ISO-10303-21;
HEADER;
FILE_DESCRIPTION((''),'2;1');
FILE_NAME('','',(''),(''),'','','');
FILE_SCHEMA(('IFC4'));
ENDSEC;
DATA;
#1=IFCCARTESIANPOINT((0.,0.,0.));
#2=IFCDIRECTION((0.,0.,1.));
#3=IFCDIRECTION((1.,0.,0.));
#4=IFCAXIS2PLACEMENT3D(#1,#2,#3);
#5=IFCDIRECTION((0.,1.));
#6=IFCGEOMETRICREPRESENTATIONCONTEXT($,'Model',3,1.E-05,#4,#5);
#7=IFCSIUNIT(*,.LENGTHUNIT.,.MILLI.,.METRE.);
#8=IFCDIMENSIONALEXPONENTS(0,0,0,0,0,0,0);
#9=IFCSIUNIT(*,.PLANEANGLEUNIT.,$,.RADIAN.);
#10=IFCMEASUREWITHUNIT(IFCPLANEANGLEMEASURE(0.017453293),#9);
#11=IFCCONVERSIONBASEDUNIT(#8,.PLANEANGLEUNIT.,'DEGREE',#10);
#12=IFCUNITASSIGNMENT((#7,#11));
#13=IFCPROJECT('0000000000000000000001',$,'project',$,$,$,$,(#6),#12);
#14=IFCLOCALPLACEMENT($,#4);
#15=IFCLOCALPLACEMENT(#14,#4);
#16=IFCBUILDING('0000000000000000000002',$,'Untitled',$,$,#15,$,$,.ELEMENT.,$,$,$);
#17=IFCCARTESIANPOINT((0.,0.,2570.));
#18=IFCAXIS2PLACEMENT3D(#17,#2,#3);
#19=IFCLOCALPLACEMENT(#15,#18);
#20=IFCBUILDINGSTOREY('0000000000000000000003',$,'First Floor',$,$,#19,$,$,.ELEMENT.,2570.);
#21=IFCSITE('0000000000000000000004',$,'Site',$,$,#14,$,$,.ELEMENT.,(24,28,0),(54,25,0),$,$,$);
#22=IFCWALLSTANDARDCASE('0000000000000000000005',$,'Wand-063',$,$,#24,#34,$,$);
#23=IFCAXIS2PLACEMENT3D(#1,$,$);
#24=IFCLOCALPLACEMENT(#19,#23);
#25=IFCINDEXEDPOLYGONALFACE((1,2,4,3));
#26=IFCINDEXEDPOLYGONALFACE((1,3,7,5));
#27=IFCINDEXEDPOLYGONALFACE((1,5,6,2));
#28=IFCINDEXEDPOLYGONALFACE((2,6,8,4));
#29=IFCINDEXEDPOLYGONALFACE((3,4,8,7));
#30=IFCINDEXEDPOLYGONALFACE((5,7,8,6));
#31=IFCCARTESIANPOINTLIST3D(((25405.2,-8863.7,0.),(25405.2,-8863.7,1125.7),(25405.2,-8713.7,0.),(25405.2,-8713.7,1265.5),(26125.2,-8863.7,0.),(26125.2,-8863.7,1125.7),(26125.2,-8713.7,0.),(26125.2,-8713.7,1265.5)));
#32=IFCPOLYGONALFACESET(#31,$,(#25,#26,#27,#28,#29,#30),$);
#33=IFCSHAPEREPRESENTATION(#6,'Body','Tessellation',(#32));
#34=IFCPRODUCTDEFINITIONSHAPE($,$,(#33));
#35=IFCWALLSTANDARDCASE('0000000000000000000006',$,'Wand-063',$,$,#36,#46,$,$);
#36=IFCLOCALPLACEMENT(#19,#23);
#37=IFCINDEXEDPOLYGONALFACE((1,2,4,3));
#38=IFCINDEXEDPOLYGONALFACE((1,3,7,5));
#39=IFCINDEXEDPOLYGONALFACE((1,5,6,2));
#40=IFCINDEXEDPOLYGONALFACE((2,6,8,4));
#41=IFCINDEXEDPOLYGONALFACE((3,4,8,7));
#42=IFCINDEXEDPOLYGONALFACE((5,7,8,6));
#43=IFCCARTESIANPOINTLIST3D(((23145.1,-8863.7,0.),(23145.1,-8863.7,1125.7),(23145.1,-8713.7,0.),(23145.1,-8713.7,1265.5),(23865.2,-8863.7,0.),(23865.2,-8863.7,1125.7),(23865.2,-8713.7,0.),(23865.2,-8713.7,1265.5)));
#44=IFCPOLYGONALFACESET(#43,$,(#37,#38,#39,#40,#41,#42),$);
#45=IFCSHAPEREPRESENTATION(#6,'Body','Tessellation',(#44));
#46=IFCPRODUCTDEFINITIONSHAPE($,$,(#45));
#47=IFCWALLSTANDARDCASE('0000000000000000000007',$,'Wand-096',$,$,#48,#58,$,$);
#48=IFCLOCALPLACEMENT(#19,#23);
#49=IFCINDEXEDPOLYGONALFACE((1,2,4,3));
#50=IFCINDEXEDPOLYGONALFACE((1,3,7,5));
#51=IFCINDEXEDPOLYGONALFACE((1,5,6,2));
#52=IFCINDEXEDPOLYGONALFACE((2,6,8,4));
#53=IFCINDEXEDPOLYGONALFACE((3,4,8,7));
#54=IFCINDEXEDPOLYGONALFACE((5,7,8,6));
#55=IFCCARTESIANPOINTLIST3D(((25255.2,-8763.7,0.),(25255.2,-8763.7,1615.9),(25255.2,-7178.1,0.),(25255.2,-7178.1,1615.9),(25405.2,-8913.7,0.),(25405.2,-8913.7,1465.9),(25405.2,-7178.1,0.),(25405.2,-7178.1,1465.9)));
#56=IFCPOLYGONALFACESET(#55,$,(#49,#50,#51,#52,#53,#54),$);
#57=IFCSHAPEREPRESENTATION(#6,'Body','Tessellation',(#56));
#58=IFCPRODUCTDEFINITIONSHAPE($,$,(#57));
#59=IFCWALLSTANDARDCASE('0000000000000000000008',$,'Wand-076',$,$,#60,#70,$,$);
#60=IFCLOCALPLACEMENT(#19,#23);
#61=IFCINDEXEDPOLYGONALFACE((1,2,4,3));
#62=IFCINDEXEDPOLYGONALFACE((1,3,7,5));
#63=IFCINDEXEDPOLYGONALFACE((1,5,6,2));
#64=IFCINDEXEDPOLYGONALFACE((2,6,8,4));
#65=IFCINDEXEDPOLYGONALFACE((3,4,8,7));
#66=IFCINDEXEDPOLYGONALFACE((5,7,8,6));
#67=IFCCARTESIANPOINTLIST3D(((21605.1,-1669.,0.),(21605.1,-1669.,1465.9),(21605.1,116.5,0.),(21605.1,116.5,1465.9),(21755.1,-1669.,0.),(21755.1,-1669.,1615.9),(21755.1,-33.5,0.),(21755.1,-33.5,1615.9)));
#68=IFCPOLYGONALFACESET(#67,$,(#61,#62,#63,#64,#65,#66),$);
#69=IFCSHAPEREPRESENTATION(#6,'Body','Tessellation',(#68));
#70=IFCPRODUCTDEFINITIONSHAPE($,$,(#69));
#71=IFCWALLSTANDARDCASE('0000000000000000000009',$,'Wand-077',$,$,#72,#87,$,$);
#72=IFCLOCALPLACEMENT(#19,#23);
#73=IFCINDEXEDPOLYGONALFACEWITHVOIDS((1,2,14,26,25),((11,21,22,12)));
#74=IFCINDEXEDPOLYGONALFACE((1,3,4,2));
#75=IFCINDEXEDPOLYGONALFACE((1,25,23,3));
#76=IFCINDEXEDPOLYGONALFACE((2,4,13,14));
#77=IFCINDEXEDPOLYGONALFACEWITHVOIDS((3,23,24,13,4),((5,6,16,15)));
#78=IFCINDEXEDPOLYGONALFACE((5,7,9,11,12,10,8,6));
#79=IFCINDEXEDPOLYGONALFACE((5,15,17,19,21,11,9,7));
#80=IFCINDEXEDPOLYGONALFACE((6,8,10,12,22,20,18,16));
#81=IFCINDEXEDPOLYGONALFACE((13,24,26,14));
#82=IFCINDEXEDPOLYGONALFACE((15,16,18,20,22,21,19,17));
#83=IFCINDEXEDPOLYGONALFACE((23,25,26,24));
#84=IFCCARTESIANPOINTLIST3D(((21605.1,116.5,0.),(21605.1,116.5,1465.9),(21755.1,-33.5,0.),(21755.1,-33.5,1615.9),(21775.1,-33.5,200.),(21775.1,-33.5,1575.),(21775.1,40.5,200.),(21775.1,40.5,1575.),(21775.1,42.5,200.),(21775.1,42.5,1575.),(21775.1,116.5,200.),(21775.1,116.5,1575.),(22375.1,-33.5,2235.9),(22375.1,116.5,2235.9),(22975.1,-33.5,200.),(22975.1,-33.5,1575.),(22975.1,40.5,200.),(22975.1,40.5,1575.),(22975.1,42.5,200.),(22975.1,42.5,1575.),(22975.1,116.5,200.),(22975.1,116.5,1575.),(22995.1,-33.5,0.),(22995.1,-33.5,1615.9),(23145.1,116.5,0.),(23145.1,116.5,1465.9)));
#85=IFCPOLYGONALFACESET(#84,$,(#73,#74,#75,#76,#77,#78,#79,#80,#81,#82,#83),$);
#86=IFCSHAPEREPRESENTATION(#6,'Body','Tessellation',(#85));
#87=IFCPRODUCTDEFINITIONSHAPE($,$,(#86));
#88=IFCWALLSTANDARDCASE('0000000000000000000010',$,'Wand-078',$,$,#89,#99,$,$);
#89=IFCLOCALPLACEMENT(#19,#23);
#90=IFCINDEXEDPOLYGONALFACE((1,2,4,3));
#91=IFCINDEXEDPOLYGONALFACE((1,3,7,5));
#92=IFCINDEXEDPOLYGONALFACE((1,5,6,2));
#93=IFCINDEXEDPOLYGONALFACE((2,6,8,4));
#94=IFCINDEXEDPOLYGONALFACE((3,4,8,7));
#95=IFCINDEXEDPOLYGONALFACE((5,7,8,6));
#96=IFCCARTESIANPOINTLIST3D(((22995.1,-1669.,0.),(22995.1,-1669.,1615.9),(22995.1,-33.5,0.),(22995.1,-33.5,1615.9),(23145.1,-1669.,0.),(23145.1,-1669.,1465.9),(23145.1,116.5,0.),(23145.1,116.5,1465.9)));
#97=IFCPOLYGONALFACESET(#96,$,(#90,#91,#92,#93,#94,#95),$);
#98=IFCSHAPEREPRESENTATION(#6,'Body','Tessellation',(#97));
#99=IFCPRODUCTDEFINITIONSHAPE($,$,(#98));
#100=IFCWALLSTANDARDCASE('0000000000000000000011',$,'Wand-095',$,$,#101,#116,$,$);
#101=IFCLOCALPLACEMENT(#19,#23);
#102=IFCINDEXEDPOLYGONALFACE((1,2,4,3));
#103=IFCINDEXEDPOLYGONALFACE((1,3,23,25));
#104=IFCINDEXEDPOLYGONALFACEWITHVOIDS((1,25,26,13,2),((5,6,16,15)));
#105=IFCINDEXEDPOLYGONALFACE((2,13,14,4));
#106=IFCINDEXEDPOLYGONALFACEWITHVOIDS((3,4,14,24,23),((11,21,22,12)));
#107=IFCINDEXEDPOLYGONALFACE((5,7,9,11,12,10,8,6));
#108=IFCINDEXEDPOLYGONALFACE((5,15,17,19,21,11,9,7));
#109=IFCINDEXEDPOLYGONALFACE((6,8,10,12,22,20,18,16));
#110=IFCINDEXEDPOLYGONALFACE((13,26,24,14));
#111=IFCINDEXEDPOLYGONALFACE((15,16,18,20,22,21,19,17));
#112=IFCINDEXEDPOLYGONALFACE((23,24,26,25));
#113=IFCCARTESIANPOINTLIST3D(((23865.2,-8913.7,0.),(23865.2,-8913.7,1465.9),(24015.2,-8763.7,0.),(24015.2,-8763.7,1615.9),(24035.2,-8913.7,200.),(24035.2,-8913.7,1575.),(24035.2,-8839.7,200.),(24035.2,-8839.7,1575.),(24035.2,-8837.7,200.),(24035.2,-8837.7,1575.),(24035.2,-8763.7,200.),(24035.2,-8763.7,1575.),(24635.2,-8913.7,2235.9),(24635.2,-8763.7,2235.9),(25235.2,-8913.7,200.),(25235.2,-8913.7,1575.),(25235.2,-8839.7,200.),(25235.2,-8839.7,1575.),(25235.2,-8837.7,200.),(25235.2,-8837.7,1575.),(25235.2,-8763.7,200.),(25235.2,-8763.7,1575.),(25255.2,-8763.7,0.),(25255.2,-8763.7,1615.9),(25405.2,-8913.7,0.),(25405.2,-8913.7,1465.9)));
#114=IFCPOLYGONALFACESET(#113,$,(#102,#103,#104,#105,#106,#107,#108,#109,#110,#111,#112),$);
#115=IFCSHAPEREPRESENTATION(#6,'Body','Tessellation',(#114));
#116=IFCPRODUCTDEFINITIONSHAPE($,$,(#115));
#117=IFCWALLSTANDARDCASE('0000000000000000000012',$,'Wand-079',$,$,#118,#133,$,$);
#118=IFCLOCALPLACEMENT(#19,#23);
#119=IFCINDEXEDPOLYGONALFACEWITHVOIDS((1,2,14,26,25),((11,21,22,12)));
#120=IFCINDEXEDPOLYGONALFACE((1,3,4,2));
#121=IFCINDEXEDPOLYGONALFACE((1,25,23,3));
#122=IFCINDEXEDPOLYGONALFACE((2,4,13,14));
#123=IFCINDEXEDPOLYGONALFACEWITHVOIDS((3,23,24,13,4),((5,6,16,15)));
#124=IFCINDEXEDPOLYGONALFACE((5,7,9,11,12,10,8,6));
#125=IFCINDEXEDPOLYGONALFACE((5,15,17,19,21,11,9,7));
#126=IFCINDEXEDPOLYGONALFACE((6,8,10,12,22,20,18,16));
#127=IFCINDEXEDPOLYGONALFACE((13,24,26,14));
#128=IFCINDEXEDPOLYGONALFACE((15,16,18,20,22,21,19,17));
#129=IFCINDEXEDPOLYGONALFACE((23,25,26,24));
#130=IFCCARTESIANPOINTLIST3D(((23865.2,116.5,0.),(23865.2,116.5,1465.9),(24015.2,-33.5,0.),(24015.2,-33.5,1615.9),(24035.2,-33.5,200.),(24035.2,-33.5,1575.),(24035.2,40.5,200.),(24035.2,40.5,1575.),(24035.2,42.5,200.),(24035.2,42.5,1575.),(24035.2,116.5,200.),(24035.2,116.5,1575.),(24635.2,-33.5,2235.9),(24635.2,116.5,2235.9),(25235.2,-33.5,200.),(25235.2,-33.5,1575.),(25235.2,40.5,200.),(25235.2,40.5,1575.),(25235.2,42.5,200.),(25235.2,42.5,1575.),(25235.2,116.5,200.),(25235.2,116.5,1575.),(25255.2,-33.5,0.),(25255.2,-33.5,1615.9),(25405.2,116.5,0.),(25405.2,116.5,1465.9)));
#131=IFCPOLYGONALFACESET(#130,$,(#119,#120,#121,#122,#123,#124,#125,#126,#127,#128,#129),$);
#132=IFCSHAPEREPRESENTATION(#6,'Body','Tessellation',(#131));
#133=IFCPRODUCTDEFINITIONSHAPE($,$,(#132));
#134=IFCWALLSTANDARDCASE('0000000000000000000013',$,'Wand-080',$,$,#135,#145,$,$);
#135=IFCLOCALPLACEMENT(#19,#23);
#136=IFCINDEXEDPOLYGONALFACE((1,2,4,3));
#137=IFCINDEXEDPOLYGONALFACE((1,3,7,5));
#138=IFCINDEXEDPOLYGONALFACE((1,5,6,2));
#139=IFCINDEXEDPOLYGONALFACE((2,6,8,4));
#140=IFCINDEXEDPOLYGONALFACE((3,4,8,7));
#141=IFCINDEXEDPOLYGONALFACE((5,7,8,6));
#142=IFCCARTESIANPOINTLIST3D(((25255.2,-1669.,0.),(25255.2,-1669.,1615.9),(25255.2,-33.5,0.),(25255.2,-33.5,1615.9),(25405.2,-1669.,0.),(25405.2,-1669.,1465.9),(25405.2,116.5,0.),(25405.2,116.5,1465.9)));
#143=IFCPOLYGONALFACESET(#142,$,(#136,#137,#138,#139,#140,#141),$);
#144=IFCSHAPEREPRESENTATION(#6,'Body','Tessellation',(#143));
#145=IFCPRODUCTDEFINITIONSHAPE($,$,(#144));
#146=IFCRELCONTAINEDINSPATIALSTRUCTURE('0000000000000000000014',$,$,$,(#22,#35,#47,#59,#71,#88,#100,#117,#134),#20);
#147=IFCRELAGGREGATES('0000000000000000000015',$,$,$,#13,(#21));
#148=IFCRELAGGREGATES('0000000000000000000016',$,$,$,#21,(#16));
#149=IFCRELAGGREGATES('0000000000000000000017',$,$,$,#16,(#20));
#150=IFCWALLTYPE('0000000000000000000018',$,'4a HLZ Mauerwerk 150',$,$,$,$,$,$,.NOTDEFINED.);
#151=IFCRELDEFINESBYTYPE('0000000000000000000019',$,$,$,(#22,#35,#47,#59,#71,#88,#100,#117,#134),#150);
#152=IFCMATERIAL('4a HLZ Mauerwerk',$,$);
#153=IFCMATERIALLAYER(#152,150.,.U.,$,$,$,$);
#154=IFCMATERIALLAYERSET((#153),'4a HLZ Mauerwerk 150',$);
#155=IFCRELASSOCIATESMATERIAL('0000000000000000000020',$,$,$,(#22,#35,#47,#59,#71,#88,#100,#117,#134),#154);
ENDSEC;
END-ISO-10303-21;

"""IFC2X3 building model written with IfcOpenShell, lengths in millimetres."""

from ifc_helpers import new_model, entity, si_unit, converted_unit, direction, frame, origin_with_axes, origin_2d_with_axis, place, context, project, spatial, polyline, rectangle, outline, extrude, clip, halfspace, bounded_halfspace, material, layer, layer_set, layer_usage, type_object, element, save


model = new_model("IFC2X3")

# Units and contexts
model_context = context("Model", 3, precision=1e-05, world=origin_with_axes(), true_north=direction((0.0, 1.0)))
ifc_project = project(units=[si_unit("LENGTHUNIT", "METRE", prefix="MILLI"), converted_unit("PLANEANGLEUNIT", "DEGREE", entity("IfcPlaneAngleMeasure", 0.017453293), si_unit("PLANEANGLEUNIT", "RADIAN"), dimensions=[0, 0, 0, 0, 0, 0, 0])], contexts=[model_context])

# Site, building, storey
site_placement = place(None, origin_with_axes())
site = spatial("IfcSite", under=ifc_project, at=site_placement, Name="Site", CompositionType="ELEMENT", RefLatitude=(24, 28, 0), RefLongitude=(54, 25, 0))
building_placement = place(site_placement, origin_with_axes())
building = spatial("IfcBuilding", under=site, at=building_placement, Name="Untitled", CompositionType="ELEMENT")
storey_placement = place(building_placement, frame((0.0, 0.0, 2570.0), z_axis=(0.0, 0.0, 1.0), x_axis=(1.0, 0.0, 0.0)))
storey = spatial("IfcBuildingStorey", under=building, at=storey_placement, Name="First Floor", CompositionType="ELEMENT", Elevation=2570.0)

# Walls
ifc_material = material(Name="4a HLZ Mauerwerk")
ifc_layer_1 = layer(ifc_material, 150.0, ventilated="UNKNOWN")
ifc_layer_set_1 = layer_set([ifc_layer_1], Name="4a HLZ Mauerwerk 150")
ifc_layer_usage_1 = layer_usage(ifc_layer_set_1, "AXIS2", "POSITIVE", 0.0)
wall_type_1 = type_object("IfcWallType", Name="4a HLZ Mauerwerk 150", PredefinedType="NOTDEFINED")
wall_1_placement = place(storey_placement, frame((25405.2, -8863.7, 0.0), z_axis=(0.0, 0.0, 1.0), x_axis=(1.0, 0.0, 0.0)))
element("IfcWallStandardCase", 1, at=wall_1_placement, inside=storey, type_object=wall_type_1, material=ifc_layer_usage_1, Name="Wand-063", context=model_context, shape_type="Clipping", body=[
    clip(extrude(outline(polyline([(0.0, 0.0), (720.0, 0.0), (720.0, 150.0), (0.0, 150.0), (0.0, 0.0)])), origin_with_axes(), (0.0, 0.0, 1.0), 5316.0), bounded_halfspace(frame((0.0, -561.5, 602.1), z_axis=(0.0, 0.681998, -0.731354), x_axis=(0.0, -0.731354, -0.681998)), True, origin_with_axes(), polyline([(0.0, 0.0), (720.0, 0.0), (720.0, 150.0), (0.0, 150.0), (0.0, 0.0)]))),
])
ifc_layer_usage_2 = layer_usage(ifc_layer_set_1, "AXIS2", "POSITIVE", 0.0)
wall_2_placement = place(storey_placement, frame((23145.1, -8863.7, 0.0), z_axis=(0.0, 0.0, 1.0), x_axis=(1.0, 0.0, 0.0)))
element("IfcWallStandardCase", 2, at=wall_2_placement, inside=storey, type_object=wall_type_1, material=ifc_layer_usage_2, Name="Wand-063", context=model_context, shape_type="Clipping", body=[
    clip(extrude(outline(polyline([(0.0, 0.0), (720.0, 0.0), (720.0, 150.0), (0.0, 150.0), (0.0, 0.0)])), origin_with_axes(), (0.0, 0.0, 1.0), 5316.0), halfspace(frame((0.0, -561.5, 602.1), z_axis=(0.0, 0.681998, -0.731354), x_axis=(0.0, -0.731354, -0.681998)), True)),
])
ifc_layer_usage_3 = layer_usage(ifc_layer_set_1, "AXIS2", "POSITIVE", 0.0)
wall_3_placement = place(storey_placement, frame((25405.2, -8913.7, 0.0), z_axis=(0.0, 0.0, 1.0), x_axis=(0.0, 1.0, 0.0)))
element("IfcWallStandardCase", 3, at=wall_3_placement, inside=storey, type_object=wall_type_1, material=ifc_layer_usage_3, Name="Wand-096", context=model_context, shape_type="Clipping", body=[
    clip(extrude(outline(polyline([(0.0, 0.0), (1735.6, 0.0), (1735.6, 150.0), (150.0, 150.0), (0.0, 0.0)])), origin_with_axes(), (0.0, 0.0, 1.0), 5316.0), halfspace(frame((0.0, -733.0, 733.0), z_axis=(0.0, 0.707107, -0.707107), x_axis=(0.0, -0.707107, -0.707107)), True)),
])
ifc_layer_usage_4 = layer_usage(ifc_layer_set_1, "AXIS2", "POSITIVE", 0.0)
wall_4_placement = place(storey_placement, frame((21605.1, 116.5, 0.0), z_axis=(0.0, 0.0, 1.0), x_axis=(0.0, -1.0, 0.0)))
element("IfcWallStandardCase", 4, at=wall_4_placement, inside=storey, type_object=wall_type_1, material=ifc_layer_usage_4, Name="Wand-076", context=model_context, shape_type="Clipping", body=[
    clip(extrude(outline(polyline([(0.0, 0.0), (1785.6, 0.0), (1785.6, 150.0), (150.0, 150.0), (0.0, 0.0)])), origin_with_axes(), (0.0, 0.0, 1.0), 5316.0), halfspace(frame((0.0, -733.0, 733.0), z_axis=(0.0, 0.707107, -0.707107), x_axis=(0.0, -0.707107, -0.707107)), True)),
])

# Wall, opening
ifc_layer_usage_5 = layer_usage(ifc_layer_set_1, "AXIS2", "NEGATIVE", 0.0)
wall_5_placement = place(storey_placement, frame((21605.1, 116.5, 0.0), z_axis=(0.0, 0.0, 1.0), x_axis=(1.0, 0.0, 0.0)))
wall_5 = element("IfcWallStandardCase", 5, at=wall_5_placement, inside=storey, type_object=wall_type_1, material=ifc_layer_usage_5, Name="Wand-077", context=model_context, shape_type="Clipping", body=[
    clip(clip(extrude(outline(polyline([(150.0, -150.0), (1390.0, -150.0), (1540.0, 0.0), (0.0, 0.0), (150.0, -150.0)])), origin_with_axes(), (0.0, 0.0, 1.0), 5316.0), bounded_halfspace(frame((1503.0, 0.0, 1503.0), z_axis=(-0.707107, 0.0, -0.707107), x_axis=(0.707107, 0.0, -0.707107)), True, origin_with_axes(), polyline([(770.0, -150.0), (1540.0, -150.0), (1540.0, 0.0), (770.0, 0.0), (770.0, -150.0)]))), bounded_halfspace(frame((-733.0, 0.0, 733.0), z_axis=(0.707107, 0.0, -0.707107), x_axis=(0.707107, 0.0, 0.707107)), True, origin_with_axes(), polyline([(0.0, -150.0), (770.0, -150.0), (770.0, 0.0), (0.0, 0.0), (0.0, -150.0)]))),
])
opening_1_placement = place(wall_5_placement, frame((770.0, 0.0, 200.0), z_axis=(0.0, 0.0, 1.0), x_axis=(1.0, 0.0, 0.0)))
element("IfcOpeningElement", 6, at=opening_1_placement, cuts=wall_5, context=model_context, shape_type="SweptSolid", body=[
    extrude(rectangle(XDim=1200.0, YDim=1375.0, at=origin_2d_with_axis()), frame((0.0, 226.0, 687.5), z_axis=(0.0, -1.0, 0.0), x_axis=(1.0, 0.0, 0.0)), (0.0, 0.0, 1.0), 302.0),
    extrude(rectangle(XDim=1200.0, YDim=1375.0, at=origin_2d_with_axis()), frame((0.0, -376.0, 687.5), z_axis=(0.0, 1.0, 0.0), x_axis=(1.0, 0.0, 0.0)), (0.0, 0.0, 1.0), 302.0),
])

# Wall
ifc_layer_usage_6 = layer_usage(ifc_layer_set_1, "AXIS2", "NEGATIVE", 0.0)
wall_6_placement = place(storey_placement, frame((23145.1, 116.5, 0.0), z_axis=(0.0, 0.0, 1.0), x_axis=(0.0, -1.0, 0.0)))
element("IfcWallStandardCase", 7, at=wall_6_placement, inside=storey, type_object=wall_type_1, material=ifc_layer_usage_6, Name="Wand-078", context=model_context, shape_type="Clipping", body=[
    clip(extrude(outline(polyline([(150.0, -150.0), (1785.6, -150.0), (1785.6, 0.0), (0.0, 0.0), (150.0, -150.0)])), origin_with_axes(), (0.0, 0.0, 1.0), 5316.0), halfspace(frame((0.0, 733.0, 733.0), z_axis=(0.0, -0.707107, -0.707107), x_axis=(0.0, -0.707107, 0.707107)), True)),
])

# Walls, openings
ifc_layer_usage_7 = layer_usage(ifc_layer_set_1, "AXIS2", "POSITIVE", 0.0)
wall_7_placement = place(storey_placement, frame((23865.2, -8913.7, 0.0), z_axis=(0.0, 0.0, 1.0), x_axis=(1.0, 0.0, 0.0)))
wall_7 = element("IfcWallStandardCase", 8, at=wall_7_placement, inside=storey, type_object=wall_type_1, material=ifc_layer_usage_7, Name="Wand-095", context=model_context, shape_type="Clipping", body=[
    clip(clip(extrude(outline(polyline([(0.0, 0.0), (1540.0, 0.0), (1390.0, 150.0), (150.0, 150.0), (0.0, 0.0)])), origin_with_axes(), (0.0, 0.0, 1.0), 5316.0), bounded_halfspace(frame((-733.0, 0.0, 733.0), z_axis=(0.707107, 0.0, -0.707107), x_axis=(0.707107, 0.0, 0.707107)), True, origin_with_axes(), polyline([(0.0, 0.0), (770.0, 0.0), (770.0, 150.0), (0.0, 150.0), (0.0, 0.0)]))), bounded_halfspace(frame((1503.0, 0.0, 1503.0), z_axis=(-0.707107, 0.0, -0.707107), x_axis=(0.707107, 0.0, -0.707107)), True, origin_with_axes(), polyline([(770.0, 0.0), (1540.0, 0.0), (1540.0, 150.0), (770.0, 150.0), (770.0, 0.0)]))),
])
opening_2_placement = place(wall_7_placement, frame((770.0, 0.0, 200.0), z_axis=(0.0, 0.0, 1.0), x_axis=(1.0, 0.0, 0.0)))
element("IfcOpeningElement", 9, at=opening_2_placement, cuts=wall_7, context=model_context, shape_type="SweptSolid", body=[
    extrude(rectangle(XDim=1200.0, YDim=1375.0, at=origin_2d_with_axis()), frame((0.0, -226.0, 687.5), z_axis=(0.0, 1.0, 0.0), x_axis=(1.0, 0.0, 0.0)), (0.0, 0.0, 1.0), 302.0),
    extrude(rectangle(XDim=1200.0, YDim=1375.0, at=origin_2d_with_axis()), frame((0.0, 376.0, 687.5), z_axis=(0.0, -1.0, 0.0), x_axis=(1.0, 0.0, 0.0)), (0.0, 0.0, 1.0), 302.0),
])
ifc_layer_usage_8 = layer_usage(ifc_layer_set_1, "AXIS2", "NEGATIVE", 0.0)
wall_8_placement = place(storey_placement, frame((23865.2, 116.5, 0.0), z_axis=(0.0, 0.0, 1.0), x_axis=(1.0, 0.0, 0.0)))
wall_8 = element("IfcWallStandardCase", 10, at=wall_8_placement, inside=storey, type_object=wall_type_1, material=ifc_layer_usage_8, Name="Wand-079", context=model_context, shape_type="Clipping", body=[
    clip(clip(extrude(outline(polyline([(150.0, -150.0), (1390.0, -150.0), (1540.0, 0.0), (0.0, 0.0), (150.0, -150.0)])), origin_with_axes(), (0.0, 0.0, 1.0), 5316.0), bounded_halfspace(frame((-733.0, 0.0, 733.0), z_axis=(0.707107, 0.0, -0.707107), x_axis=(0.707107, 0.0, 0.707107)), True, origin_with_axes(), polyline([(0.0, -150.0), (770.0, -150.0), (770.0, 0.0), (0.0, 0.0), (0.0, -150.0)]))), bounded_halfspace(frame((1503.0, 0.0, 1503.0), z_axis=(-0.707107, 0.0, -0.707107), x_axis=(0.707107, 0.0, -0.707107)), True, origin_with_axes(), polyline([(770.0, -150.0), (1540.0, -150.0), (1540.0, 0.0), (770.0, 0.0), (770.0, -150.0)]))),
])
opening_3_placement = place(wall_8_placement, frame((770.0, 0.0, 200.0), z_axis=(0.0, 0.0, 1.0), x_axis=(1.0, 0.0, 0.0)))
element("IfcOpeningElement", 11, at=opening_3_placement, cuts=wall_8, context=model_context, shape_type="SweptSolid", body=[
    extrude(rectangle(XDim=1200.0, YDim=1375.0, at=origin_2d_with_axis()), frame((0.0, 226.0, 687.5), z_axis=(0.0, -1.0, 0.0), x_axis=(1.0, 0.0, 0.0)), (0.0, 0.0, 1.0), 302.0),
    extrude(rectangle(XDim=1200.0, YDim=1375.0, at=origin_2d_with_axis()), frame((0.0, -376.0, 687.5), z_axis=(0.0, 1.0, 0.0), x_axis=(1.0, 0.0, 0.0)), (0.0, 0.0, 1.0), 302.0),
])

# Wall
ifc_layer_usage_9 = layer_usage(ifc_layer_set_1, "AXIS2", "NEGATIVE", 0.0)
wall_9_placement = place(storey_placement, frame((25405.2, 116.5, 0.0), z_axis=(0.0, 0.0, 1.0), x_axis=(0.0, -1.0, 0.0)))
element("IfcWallStandardCase", 12, at=wall_9_placement, inside=storey, type_object=wall_type_1, material=ifc_layer_usage_9, Name="Wand-080", context=model_context, shape_type="Clipping", body=[
    clip(extrude(outline(polyline([(150.0, -150.0), (1785.6, -150.0), (1785.6, 0.0), (0.0, 0.0), (150.0, -150.0)])), origin_with_axes(), (0.0, 0.0, 1.0), 5316.0), halfspace(frame((0.0, 733.0, 733.0), z_axis=(0.0, -0.707107, -0.707107), x_axis=(0.0, -0.707107, 0.707107)), True)),
])

save(model, "model.ifc")
